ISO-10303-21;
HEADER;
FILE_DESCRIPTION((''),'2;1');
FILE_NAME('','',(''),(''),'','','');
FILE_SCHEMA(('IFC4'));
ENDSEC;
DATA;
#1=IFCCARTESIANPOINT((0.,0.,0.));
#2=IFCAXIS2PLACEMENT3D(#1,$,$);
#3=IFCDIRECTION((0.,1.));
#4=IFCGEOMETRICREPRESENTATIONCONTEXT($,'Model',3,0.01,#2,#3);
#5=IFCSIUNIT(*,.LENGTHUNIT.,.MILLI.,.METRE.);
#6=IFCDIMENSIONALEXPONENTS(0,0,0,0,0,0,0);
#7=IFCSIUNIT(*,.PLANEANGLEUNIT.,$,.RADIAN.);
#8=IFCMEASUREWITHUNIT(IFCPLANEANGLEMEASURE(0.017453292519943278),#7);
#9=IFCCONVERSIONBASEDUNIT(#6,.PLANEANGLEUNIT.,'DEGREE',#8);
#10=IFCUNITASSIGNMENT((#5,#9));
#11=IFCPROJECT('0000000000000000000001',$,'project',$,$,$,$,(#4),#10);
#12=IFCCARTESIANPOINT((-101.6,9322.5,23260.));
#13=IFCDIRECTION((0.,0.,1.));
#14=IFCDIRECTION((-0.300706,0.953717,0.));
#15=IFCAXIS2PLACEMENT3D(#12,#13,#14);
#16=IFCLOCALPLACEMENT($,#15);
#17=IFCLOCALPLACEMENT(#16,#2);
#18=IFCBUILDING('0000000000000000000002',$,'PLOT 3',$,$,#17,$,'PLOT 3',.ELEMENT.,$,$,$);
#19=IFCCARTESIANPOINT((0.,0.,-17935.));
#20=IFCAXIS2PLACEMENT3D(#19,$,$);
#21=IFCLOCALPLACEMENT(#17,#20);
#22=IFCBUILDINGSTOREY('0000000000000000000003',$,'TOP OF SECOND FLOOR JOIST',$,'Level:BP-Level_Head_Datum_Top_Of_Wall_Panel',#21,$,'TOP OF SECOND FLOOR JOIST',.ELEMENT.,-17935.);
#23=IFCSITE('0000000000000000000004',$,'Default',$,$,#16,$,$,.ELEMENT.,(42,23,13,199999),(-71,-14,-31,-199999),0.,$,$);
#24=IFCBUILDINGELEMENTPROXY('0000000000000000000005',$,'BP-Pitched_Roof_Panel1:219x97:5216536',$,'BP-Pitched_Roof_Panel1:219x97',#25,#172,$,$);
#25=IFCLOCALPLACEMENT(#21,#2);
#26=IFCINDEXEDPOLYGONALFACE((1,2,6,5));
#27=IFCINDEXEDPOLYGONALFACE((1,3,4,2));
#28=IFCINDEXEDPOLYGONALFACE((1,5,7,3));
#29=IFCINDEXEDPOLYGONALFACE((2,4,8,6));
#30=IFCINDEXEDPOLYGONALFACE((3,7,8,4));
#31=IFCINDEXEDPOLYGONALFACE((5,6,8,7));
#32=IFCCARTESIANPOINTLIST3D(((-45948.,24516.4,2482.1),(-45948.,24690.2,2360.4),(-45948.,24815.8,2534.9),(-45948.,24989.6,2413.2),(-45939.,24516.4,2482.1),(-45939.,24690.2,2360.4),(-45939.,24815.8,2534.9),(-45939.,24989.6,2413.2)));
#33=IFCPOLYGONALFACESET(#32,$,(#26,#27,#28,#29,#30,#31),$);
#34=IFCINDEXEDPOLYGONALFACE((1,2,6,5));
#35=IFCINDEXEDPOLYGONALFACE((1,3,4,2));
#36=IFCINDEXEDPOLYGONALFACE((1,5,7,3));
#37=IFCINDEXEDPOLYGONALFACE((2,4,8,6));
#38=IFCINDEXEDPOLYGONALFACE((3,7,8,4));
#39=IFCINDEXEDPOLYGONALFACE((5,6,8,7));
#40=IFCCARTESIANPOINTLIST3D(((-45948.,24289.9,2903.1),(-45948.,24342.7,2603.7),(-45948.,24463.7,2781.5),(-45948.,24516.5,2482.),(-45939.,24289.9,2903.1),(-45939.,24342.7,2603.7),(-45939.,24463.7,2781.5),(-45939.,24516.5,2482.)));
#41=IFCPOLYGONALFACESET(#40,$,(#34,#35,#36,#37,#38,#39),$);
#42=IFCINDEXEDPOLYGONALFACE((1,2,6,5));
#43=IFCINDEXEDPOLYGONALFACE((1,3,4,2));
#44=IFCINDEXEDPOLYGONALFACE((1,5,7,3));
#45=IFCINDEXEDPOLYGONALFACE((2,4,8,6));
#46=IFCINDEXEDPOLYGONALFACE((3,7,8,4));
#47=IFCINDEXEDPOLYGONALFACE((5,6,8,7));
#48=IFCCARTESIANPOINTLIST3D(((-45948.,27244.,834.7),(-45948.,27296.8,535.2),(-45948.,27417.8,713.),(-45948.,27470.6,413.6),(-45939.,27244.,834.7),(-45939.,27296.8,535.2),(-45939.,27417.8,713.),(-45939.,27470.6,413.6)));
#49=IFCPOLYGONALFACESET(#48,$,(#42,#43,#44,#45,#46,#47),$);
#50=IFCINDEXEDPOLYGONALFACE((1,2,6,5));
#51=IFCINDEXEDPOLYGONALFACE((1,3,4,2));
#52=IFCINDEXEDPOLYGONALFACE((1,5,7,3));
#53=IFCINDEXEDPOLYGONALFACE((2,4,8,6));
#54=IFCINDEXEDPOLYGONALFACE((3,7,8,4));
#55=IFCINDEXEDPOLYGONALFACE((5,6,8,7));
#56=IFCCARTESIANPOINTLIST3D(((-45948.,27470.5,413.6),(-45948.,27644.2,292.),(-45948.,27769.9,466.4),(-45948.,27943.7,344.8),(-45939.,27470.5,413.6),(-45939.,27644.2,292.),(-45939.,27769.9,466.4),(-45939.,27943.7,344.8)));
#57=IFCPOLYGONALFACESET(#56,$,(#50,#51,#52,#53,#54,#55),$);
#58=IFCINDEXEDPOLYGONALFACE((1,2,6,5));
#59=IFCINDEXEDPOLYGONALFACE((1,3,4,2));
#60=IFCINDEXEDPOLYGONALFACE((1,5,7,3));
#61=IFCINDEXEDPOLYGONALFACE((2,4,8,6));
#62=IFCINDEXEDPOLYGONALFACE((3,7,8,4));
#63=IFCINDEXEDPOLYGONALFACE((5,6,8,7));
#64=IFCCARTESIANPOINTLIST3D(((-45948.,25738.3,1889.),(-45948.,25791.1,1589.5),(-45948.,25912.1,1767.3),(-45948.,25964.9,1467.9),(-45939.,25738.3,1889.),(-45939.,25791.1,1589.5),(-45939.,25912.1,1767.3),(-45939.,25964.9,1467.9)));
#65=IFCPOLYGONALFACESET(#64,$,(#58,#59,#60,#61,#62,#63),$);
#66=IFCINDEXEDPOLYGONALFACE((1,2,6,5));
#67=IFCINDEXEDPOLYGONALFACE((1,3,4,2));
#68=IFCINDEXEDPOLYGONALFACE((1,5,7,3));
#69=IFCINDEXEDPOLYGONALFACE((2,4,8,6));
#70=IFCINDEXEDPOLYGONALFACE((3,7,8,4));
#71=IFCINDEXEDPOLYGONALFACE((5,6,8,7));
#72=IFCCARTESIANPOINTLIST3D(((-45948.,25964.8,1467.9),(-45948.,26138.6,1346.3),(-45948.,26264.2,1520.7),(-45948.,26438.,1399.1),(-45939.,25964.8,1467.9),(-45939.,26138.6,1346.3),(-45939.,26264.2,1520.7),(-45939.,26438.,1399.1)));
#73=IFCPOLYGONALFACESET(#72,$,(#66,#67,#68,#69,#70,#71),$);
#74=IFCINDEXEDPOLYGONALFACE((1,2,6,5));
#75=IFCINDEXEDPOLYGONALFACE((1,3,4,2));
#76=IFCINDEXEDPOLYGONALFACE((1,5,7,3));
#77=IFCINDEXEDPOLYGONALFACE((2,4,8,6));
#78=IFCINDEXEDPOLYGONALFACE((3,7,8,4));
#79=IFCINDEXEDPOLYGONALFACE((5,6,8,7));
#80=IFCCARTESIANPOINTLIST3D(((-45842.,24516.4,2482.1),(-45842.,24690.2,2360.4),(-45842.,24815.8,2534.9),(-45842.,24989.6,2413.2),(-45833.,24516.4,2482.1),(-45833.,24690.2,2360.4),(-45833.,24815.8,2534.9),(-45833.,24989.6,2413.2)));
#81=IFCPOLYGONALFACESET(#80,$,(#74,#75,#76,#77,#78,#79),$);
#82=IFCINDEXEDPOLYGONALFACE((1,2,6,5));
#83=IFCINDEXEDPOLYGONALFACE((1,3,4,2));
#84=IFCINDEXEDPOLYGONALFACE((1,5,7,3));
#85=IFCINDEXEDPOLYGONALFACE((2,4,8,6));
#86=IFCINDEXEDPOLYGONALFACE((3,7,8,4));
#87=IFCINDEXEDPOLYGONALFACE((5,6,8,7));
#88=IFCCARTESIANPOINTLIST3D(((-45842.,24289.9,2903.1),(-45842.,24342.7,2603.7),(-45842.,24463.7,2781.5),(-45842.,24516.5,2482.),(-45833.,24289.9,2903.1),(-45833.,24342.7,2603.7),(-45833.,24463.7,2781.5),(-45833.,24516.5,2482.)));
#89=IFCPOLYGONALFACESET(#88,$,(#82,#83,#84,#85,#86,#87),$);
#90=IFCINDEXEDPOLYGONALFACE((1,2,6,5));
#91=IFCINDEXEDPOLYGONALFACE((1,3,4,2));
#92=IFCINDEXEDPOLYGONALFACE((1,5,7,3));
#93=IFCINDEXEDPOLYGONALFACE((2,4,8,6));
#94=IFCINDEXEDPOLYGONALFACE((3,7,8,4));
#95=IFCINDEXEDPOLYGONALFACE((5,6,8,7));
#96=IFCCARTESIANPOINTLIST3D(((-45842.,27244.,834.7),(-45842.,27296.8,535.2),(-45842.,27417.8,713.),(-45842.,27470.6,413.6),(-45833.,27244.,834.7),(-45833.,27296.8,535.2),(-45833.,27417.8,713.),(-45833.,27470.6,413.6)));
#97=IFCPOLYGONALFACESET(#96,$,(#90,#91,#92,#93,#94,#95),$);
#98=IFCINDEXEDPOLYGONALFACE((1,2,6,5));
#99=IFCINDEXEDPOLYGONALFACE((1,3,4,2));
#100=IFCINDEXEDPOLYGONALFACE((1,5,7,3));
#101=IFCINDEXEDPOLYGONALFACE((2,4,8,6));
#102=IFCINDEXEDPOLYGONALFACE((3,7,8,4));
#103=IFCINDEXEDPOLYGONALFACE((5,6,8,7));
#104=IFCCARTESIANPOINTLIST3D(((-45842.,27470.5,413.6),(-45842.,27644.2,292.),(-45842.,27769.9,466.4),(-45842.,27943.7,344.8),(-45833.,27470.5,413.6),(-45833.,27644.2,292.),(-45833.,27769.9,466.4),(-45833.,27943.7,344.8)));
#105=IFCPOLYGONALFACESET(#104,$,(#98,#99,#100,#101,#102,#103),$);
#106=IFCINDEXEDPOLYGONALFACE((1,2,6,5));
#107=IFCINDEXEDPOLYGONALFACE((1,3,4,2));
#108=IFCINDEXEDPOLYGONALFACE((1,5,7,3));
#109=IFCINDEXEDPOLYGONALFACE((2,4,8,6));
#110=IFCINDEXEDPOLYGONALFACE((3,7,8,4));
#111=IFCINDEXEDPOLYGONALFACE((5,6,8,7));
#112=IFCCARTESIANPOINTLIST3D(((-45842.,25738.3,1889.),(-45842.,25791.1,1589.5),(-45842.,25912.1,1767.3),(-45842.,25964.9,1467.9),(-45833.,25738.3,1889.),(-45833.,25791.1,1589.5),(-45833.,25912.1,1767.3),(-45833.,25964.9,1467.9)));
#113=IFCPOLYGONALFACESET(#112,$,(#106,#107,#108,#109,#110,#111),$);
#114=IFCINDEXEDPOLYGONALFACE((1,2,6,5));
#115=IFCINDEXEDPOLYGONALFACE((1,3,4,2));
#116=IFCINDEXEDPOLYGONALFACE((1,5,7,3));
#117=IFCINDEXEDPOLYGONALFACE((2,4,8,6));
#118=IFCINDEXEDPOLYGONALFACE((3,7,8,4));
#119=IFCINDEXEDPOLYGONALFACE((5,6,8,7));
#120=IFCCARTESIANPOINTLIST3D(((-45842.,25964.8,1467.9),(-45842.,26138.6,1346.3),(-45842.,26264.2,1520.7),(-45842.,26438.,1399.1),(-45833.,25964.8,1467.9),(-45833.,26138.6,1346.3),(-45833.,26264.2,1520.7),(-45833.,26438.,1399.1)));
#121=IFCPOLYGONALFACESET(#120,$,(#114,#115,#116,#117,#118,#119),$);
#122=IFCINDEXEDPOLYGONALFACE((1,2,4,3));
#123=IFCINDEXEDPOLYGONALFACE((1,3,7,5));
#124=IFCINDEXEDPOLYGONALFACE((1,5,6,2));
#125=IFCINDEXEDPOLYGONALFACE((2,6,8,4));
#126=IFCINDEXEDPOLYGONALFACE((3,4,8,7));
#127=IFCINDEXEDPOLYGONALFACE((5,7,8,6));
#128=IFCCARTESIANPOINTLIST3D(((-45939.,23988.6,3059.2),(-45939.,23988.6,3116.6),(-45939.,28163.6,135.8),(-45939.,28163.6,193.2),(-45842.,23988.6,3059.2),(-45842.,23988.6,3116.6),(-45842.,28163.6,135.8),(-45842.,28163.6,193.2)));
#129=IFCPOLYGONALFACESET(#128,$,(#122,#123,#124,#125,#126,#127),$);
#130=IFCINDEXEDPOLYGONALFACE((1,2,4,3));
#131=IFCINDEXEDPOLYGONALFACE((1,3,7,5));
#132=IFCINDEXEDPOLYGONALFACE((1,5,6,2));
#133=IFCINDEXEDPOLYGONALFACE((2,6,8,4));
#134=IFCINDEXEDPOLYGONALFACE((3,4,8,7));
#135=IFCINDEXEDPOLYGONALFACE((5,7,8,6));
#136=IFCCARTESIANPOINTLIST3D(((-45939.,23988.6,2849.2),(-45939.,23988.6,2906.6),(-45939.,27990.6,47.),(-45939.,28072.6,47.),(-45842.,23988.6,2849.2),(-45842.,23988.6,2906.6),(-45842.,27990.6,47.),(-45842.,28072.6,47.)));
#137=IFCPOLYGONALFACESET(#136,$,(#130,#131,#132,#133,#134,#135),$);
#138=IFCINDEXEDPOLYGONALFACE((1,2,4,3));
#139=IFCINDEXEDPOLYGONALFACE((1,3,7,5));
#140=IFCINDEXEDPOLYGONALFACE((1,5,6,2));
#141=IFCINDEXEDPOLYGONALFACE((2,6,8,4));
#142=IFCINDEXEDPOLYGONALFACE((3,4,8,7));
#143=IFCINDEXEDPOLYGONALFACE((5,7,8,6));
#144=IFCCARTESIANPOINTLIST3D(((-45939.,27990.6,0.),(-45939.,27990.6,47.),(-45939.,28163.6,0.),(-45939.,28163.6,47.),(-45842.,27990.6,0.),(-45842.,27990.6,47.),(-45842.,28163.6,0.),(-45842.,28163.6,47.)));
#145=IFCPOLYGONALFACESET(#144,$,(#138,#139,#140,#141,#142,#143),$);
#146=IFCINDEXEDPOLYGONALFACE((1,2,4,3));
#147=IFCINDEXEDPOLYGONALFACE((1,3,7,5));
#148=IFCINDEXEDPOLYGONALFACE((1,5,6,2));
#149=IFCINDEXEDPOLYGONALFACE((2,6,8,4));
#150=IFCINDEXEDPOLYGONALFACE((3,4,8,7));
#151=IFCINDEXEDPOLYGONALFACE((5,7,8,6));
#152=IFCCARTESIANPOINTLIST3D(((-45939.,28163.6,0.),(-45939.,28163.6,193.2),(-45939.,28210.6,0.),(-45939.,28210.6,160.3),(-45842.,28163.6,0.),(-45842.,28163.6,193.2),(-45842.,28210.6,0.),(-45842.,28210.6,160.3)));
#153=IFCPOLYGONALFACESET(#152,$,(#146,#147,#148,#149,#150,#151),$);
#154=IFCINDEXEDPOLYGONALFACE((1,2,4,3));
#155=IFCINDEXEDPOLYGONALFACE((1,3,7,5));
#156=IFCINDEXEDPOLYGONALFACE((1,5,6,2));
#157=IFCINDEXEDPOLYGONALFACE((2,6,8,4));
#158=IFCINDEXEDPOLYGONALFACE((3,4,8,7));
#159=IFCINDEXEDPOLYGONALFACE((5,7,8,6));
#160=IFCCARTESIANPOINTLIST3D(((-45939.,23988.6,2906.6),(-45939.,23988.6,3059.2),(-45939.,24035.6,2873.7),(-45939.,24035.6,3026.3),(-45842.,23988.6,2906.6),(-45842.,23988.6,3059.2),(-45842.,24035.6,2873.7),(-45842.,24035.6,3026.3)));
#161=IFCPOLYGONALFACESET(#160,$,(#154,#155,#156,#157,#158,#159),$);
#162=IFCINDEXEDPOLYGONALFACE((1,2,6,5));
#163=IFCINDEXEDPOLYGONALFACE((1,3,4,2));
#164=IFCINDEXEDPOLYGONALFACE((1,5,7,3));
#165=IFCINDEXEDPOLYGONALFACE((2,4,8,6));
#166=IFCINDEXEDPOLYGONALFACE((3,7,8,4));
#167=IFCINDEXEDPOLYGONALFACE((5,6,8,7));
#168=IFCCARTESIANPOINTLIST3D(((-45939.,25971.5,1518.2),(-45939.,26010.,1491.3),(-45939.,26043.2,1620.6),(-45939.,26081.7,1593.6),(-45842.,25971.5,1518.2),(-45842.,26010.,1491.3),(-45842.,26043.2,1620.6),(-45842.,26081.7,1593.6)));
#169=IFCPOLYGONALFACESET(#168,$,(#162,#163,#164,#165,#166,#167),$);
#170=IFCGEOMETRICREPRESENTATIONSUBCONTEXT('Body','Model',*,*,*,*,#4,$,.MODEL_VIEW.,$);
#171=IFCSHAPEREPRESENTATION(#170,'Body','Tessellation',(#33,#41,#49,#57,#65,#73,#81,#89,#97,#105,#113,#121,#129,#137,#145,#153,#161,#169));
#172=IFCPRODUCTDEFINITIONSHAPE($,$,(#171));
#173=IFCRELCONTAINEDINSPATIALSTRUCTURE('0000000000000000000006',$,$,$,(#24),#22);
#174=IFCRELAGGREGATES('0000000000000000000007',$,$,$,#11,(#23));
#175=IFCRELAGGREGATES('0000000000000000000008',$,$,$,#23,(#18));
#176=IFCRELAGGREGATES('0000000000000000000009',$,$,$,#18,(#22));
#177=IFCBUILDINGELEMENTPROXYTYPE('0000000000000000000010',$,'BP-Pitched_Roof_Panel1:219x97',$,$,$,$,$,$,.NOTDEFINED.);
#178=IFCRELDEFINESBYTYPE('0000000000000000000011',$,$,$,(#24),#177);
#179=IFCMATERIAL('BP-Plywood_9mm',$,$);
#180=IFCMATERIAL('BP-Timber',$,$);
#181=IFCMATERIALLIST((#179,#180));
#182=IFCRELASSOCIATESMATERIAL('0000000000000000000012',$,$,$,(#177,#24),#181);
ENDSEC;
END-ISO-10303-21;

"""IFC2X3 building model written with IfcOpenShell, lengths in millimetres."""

from ifc_helpers import new_model, entity, si_unit, converted_unit, direction, frame, frame_2d, origin, origin_2d_with_axis, place, context, subcontext, project, spatial, polyline, rectangle, outline, extrude, source, transform, mapped, material, material_list, type_object, type_shapes, element, save


model = new_model("IFC2X3")

# Units and contexts
model_context = context("Model", 3, precision=0.01, world=origin(), true_north=direction((0.0, 1.0)))
body_context = subcontext(model_context, "Body", "Model", "MODEL_VIEW")
ifc_project = project(units=[si_unit("LENGTHUNIT", "METRE", prefix="MILLI"), converted_unit("PLANEANGLEUNIT", "DEGREE", entity("IfcPlaneAngleMeasure", 0.017453292519943278), si_unit("PLANEANGLEUNIT", "RADIAN"), dimensions=[0, 0, 0, 0, 0, 0, 0])], contexts=[model_context])

# Site, building, storey
site_placement = place(None, frame((-101.6, 9322.5, 23260.0), z_axis=(0.0, 0.0, 1.0), x_axis=(-0.300706, 0.953717, 0.0)))
site = spatial("IfcSite", under=ifc_project, at=site_placement, Name="Default", CompositionType="ELEMENT", RefLatitude=(42, 23, 13, 199999), RefLongitude=(-71, -14, -31, -199999), RefElevation=0.0)
building_placement = place(site_placement, origin())
building = spatial("IfcBuilding", under=site, at=building_placement, Name="PLOT 3", LongName="PLOT 3", CompositionType="ELEMENT")
storey_placement = place(building_placement, frame((0.0, 0.0, -17935.0)))
storey = spatial("IfcBuildingStorey", under=building, at=storey_placement, Name="TOP OF SECOND FLOOR JOIST", ObjectType="Level:BP-Level_Head_Datum_Top_Of_Wall_Panel", LongName="TOP OF SECOND FLOOR JOIST", CompositionType="ELEMENT", Elevation=-17935.0)

# Building element proxy
ifc_material_1 = material(Name="BP-Timber")
ifc_material_2 = material(Name="BP-Plywood_9mm")
ifc_material_list = material_list([ifc_material_2, ifc_material_1])
building_element_proxy_type_1 = type_object("IfcBuildingElementProxyType", Name="BP-Pitched_Roof_Panel1:219x97", PredefinedType="NOTDEFINED", material=ifc_material_list)
shared_shape_1 = source(origin(), body_context, "Body", "SweptSolid", [
    extrude(outline(polyline([(-77.0, -75.0), (227.0, -75.0), (77.0, 75.0), (-227.0, 75.0), (-77.0, -75.0)])), frame((35.3, -3956.0, 2447.7), z_axis=(0.0, 1.0, 0.0), x_axis=(-0.984808, 0.0, 0.173648)), (0.0, 0.0, 1.0), 9.0),
    extrude(outline(polyline([(1.4, -107.5), (213.6, -107.5), (-1.4, 107.5), (-213.6, 107.5), (1.4, -107.5)])), frame((385.1, -3956.0, 2692.6), z_axis=(0.0, 1.0, 0.0), x_axis=(-0.819152, 0.0, -0.573576)), (0.0, 0.0, 1.0), 9.0),
    extrude(outline(polyline([(1.4, -107.5), (213.6, -107.5), (-1.4, 107.5), (-213.6, 107.5), (1.4, -107.5)])), frame((-2569.0, -3956.0, 624.1), z_axis=(0.0, 1.0, 0.0), x_axis=(-0.819152, 0.0, -0.573576)), (0.0, 0.0, 1.0), 9.0),
    extrude(outline(polyline([(-77.0, -75.0), (227.0, -75.0), (77.0, 75.0), (-227.0, 75.0), (-77.0, -75.0)])), frame((-2918.8, -3956.0, 379.2), z_axis=(0.0, 1.0, 0.0), x_axis=(-0.984808, 0.0, 0.173648)), (0.0, 0.0, 1.0), 9.0),
    extrude(outline(polyline([(1.4, -107.5), (213.6, -107.5), (-1.4, 107.5), (-213.6, 107.5), (1.4, -107.5)])), frame((-1063.3, -3956.0, 1678.4), z_axis=(0.0, 1.0, 0.0), x_axis=(-0.819152, 0.0, -0.573576)), (0.0, 0.0, 1.0), 9.0),
    extrude(outline(polyline([(-77.0, -75.0), (227.0, -75.0), (77.0, 75.0), (-227.0, 75.0), (-77.0, -75.0)])), frame((-1413.1, -3956.0, 1433.5), z_axis=(0.0, 1.0, 0.0), x_axis=(-0.984808, 0.0, 0.173648)), (0.0, 0.0, 1.0), 9.0),
    extrude(outline(polyline([(-77.0, -75.0), (227.0, -75.0), (77.0, 75.0), (-227.0, 75.0), (-77.0, -75.0)])), frame((35.3, -3850.0, 2447.7), z_axis=(0.0, 1.0, 0.0), x_axis=(-0.984808, 0.0, 0.173648)), (0.0, 0.0, 1.0), 9.0),
    extrude(outline(polyline([(1.4, -107.5), (213.6, -107.5), (-1.4, 107.5), (-213.6, 107.5), (1.4, -107.5)])), frame((385.1, -3850.0, 2692.6), z_axis=(0.0, 1.0, 0.0), x_axis=(-0.819152, 0.0, -0.573576)), (0.0, 0.0, 1.0), 9.0),
    extrude(outline(polyline([(1.4, -107.5), (213.6, -107.5), (-1.4, 107.5), (-213.6, 107.5), (1.4, -107.5)])), frame((-2569.0, -3850.0, 624.1), z_axis=(0.0, 1.0, 0.0), x_axis=(-0.819152, 0.0, -0.573576)), (0.0, 0.0, 1.0), 9.0),
    extrude(outline(polyline([(-77.0, -75.0), (227.0, -75.0), (77.0, 75.0), (-227.0, 75.0), (-77.0, -75.0)])), frame((-2918.8, -3850.0, 379.2), z_axis=(0.0, 1.0, 0.0), x_axis=(-0.984808, 0.0, 0.173648)), (0.0, 0.0, 1.0), 9.0),
    extrude(outline(polyline([(1.4, -107.5), (213.6, -107.5), (-1.4, 107.5), (-213.6, 107.5), (1.4, -107.5)])), frame((-1063.3, -3850.0, 1678.4), z_axis=(0.0, 1.0, 0.0), x_axis=(-0.819152, 0.0, -0.573576)), (0.0, 0.0, 1.0), 9.0),
    extrude(outline(polyline([(-77.0, -75.0), (227.0, -75.0), (77.0, 75.0), (-227.0, 75.0), (-77.0, -75.0)])), frame((-1413.1, -3850.0, 1433.5), z_axis=(0.0, 1.0, 0.0), x_axis=(-0.984808, 0.0, 0.173648)), (0.0, 0.0, 1.0), 9.0),
    extrude(outline(polyline([(-1490.4, -2087.5), (-1433.0, -2087.5), (1490.4, 2087.5), (1433.0, 2087.5), (-1490.4, -2087.5)])), frame((-1287.8, -3947.0, 1626.2), z_axis=(0.0, 1.0, 0.0), x_axis=(0.0, 0.0, -1.0)), (0.0, 0.0, 1.0), 97.0),
    extrude(outline(polyline([(-1444.1, -2021.5), (-1386.8, -2021.5), (1415.5, 1980.5), (1415.5, 2062.5), (-1444.1, -2021.5)])), frame((-1221.8, -3947.0, 1462.5), z_axis=(0.0, 1.0, 0.0), x_axis=(0.0, 0.0, -1.0)), (0.0, 0.0, 1.0), 97.0),
    extrude(rectangle(XDim=173.0, YDim=97.0, at=origin_2d_with_axis()), frame((-3288.8, -3898.5, 0.0), z_axis=(0.0, 0.0, 1.0), x_axis=(-1.0, 0.0, 0.0)), (0.0, 0.0, 1.0), 47.0),
    extrude(outline(polyline([(22.0, -72.4), (79.4, -72.4), (-31.4, 85.9), (-69.9, 58.9), (22.0, -72.4)])), frame((-3398.8, -3947.0, 88.4), z_axis=(0.0, 1.0, 0.0), x_axis=(0.819152, 0.0, 0.573576)), (0.0, 0.0, 1.0), 97.0),
    extrude(outline(polyline([(15.1, -62.5), (72.5, -62.5), (-15.1, 62.5), (-72.5, 62.5), (15.1, -62.5)])), frame((776.2, -3947.0, 2966.5), z_axis=(0.0, 1.0, 0.0), x_axis=(0.819152, 0.0, 0.573576)), (0.0, 0.0, 1.0), 97.0),
    extrude(rectangle(XDim=47.0, YDim=97.0, at=frame_2d((0.0, 0.0), x_axis=(1.0, 0.0))), frame((-1202.4, -3898.5, 1504.7), z_axis=(-0.573576, 0.0, 0.819152), x_axis=(-0.819152, 0.0, -0.573576)), (0.0, 0.0, 1.0), 125.0),
])
type_shapes(building_element_proxy_type_1, [shared_shape_1])
for number, where, z_axis, x_axis, name in (
    (1, (-41992.0, 24788.3, 0.0), (0.0, 0.0, 1.0), (0.0, -1.0, 0.0), "BP-Pitched_Roof_Panel1:219x97:5216536"),
):
    element("IfcBuildingElementProxy", number, at=place(storey_placement, frame(where, z_axis=z_axis, x_axis=x_axis)), inside=storey, type_object=building_element_proxy_type_1, material=ifc_material_list, Name=name, ObjectType="BP-Pitched_Roof_Panel1:219x97", context=body_context, shape_type="MappedRepresentation", body=[
        mapped(shared_shape_1, transform((0.0, 0.0, 0.0), scale=1.0)),
    ])

save(model, "model.ifc")
